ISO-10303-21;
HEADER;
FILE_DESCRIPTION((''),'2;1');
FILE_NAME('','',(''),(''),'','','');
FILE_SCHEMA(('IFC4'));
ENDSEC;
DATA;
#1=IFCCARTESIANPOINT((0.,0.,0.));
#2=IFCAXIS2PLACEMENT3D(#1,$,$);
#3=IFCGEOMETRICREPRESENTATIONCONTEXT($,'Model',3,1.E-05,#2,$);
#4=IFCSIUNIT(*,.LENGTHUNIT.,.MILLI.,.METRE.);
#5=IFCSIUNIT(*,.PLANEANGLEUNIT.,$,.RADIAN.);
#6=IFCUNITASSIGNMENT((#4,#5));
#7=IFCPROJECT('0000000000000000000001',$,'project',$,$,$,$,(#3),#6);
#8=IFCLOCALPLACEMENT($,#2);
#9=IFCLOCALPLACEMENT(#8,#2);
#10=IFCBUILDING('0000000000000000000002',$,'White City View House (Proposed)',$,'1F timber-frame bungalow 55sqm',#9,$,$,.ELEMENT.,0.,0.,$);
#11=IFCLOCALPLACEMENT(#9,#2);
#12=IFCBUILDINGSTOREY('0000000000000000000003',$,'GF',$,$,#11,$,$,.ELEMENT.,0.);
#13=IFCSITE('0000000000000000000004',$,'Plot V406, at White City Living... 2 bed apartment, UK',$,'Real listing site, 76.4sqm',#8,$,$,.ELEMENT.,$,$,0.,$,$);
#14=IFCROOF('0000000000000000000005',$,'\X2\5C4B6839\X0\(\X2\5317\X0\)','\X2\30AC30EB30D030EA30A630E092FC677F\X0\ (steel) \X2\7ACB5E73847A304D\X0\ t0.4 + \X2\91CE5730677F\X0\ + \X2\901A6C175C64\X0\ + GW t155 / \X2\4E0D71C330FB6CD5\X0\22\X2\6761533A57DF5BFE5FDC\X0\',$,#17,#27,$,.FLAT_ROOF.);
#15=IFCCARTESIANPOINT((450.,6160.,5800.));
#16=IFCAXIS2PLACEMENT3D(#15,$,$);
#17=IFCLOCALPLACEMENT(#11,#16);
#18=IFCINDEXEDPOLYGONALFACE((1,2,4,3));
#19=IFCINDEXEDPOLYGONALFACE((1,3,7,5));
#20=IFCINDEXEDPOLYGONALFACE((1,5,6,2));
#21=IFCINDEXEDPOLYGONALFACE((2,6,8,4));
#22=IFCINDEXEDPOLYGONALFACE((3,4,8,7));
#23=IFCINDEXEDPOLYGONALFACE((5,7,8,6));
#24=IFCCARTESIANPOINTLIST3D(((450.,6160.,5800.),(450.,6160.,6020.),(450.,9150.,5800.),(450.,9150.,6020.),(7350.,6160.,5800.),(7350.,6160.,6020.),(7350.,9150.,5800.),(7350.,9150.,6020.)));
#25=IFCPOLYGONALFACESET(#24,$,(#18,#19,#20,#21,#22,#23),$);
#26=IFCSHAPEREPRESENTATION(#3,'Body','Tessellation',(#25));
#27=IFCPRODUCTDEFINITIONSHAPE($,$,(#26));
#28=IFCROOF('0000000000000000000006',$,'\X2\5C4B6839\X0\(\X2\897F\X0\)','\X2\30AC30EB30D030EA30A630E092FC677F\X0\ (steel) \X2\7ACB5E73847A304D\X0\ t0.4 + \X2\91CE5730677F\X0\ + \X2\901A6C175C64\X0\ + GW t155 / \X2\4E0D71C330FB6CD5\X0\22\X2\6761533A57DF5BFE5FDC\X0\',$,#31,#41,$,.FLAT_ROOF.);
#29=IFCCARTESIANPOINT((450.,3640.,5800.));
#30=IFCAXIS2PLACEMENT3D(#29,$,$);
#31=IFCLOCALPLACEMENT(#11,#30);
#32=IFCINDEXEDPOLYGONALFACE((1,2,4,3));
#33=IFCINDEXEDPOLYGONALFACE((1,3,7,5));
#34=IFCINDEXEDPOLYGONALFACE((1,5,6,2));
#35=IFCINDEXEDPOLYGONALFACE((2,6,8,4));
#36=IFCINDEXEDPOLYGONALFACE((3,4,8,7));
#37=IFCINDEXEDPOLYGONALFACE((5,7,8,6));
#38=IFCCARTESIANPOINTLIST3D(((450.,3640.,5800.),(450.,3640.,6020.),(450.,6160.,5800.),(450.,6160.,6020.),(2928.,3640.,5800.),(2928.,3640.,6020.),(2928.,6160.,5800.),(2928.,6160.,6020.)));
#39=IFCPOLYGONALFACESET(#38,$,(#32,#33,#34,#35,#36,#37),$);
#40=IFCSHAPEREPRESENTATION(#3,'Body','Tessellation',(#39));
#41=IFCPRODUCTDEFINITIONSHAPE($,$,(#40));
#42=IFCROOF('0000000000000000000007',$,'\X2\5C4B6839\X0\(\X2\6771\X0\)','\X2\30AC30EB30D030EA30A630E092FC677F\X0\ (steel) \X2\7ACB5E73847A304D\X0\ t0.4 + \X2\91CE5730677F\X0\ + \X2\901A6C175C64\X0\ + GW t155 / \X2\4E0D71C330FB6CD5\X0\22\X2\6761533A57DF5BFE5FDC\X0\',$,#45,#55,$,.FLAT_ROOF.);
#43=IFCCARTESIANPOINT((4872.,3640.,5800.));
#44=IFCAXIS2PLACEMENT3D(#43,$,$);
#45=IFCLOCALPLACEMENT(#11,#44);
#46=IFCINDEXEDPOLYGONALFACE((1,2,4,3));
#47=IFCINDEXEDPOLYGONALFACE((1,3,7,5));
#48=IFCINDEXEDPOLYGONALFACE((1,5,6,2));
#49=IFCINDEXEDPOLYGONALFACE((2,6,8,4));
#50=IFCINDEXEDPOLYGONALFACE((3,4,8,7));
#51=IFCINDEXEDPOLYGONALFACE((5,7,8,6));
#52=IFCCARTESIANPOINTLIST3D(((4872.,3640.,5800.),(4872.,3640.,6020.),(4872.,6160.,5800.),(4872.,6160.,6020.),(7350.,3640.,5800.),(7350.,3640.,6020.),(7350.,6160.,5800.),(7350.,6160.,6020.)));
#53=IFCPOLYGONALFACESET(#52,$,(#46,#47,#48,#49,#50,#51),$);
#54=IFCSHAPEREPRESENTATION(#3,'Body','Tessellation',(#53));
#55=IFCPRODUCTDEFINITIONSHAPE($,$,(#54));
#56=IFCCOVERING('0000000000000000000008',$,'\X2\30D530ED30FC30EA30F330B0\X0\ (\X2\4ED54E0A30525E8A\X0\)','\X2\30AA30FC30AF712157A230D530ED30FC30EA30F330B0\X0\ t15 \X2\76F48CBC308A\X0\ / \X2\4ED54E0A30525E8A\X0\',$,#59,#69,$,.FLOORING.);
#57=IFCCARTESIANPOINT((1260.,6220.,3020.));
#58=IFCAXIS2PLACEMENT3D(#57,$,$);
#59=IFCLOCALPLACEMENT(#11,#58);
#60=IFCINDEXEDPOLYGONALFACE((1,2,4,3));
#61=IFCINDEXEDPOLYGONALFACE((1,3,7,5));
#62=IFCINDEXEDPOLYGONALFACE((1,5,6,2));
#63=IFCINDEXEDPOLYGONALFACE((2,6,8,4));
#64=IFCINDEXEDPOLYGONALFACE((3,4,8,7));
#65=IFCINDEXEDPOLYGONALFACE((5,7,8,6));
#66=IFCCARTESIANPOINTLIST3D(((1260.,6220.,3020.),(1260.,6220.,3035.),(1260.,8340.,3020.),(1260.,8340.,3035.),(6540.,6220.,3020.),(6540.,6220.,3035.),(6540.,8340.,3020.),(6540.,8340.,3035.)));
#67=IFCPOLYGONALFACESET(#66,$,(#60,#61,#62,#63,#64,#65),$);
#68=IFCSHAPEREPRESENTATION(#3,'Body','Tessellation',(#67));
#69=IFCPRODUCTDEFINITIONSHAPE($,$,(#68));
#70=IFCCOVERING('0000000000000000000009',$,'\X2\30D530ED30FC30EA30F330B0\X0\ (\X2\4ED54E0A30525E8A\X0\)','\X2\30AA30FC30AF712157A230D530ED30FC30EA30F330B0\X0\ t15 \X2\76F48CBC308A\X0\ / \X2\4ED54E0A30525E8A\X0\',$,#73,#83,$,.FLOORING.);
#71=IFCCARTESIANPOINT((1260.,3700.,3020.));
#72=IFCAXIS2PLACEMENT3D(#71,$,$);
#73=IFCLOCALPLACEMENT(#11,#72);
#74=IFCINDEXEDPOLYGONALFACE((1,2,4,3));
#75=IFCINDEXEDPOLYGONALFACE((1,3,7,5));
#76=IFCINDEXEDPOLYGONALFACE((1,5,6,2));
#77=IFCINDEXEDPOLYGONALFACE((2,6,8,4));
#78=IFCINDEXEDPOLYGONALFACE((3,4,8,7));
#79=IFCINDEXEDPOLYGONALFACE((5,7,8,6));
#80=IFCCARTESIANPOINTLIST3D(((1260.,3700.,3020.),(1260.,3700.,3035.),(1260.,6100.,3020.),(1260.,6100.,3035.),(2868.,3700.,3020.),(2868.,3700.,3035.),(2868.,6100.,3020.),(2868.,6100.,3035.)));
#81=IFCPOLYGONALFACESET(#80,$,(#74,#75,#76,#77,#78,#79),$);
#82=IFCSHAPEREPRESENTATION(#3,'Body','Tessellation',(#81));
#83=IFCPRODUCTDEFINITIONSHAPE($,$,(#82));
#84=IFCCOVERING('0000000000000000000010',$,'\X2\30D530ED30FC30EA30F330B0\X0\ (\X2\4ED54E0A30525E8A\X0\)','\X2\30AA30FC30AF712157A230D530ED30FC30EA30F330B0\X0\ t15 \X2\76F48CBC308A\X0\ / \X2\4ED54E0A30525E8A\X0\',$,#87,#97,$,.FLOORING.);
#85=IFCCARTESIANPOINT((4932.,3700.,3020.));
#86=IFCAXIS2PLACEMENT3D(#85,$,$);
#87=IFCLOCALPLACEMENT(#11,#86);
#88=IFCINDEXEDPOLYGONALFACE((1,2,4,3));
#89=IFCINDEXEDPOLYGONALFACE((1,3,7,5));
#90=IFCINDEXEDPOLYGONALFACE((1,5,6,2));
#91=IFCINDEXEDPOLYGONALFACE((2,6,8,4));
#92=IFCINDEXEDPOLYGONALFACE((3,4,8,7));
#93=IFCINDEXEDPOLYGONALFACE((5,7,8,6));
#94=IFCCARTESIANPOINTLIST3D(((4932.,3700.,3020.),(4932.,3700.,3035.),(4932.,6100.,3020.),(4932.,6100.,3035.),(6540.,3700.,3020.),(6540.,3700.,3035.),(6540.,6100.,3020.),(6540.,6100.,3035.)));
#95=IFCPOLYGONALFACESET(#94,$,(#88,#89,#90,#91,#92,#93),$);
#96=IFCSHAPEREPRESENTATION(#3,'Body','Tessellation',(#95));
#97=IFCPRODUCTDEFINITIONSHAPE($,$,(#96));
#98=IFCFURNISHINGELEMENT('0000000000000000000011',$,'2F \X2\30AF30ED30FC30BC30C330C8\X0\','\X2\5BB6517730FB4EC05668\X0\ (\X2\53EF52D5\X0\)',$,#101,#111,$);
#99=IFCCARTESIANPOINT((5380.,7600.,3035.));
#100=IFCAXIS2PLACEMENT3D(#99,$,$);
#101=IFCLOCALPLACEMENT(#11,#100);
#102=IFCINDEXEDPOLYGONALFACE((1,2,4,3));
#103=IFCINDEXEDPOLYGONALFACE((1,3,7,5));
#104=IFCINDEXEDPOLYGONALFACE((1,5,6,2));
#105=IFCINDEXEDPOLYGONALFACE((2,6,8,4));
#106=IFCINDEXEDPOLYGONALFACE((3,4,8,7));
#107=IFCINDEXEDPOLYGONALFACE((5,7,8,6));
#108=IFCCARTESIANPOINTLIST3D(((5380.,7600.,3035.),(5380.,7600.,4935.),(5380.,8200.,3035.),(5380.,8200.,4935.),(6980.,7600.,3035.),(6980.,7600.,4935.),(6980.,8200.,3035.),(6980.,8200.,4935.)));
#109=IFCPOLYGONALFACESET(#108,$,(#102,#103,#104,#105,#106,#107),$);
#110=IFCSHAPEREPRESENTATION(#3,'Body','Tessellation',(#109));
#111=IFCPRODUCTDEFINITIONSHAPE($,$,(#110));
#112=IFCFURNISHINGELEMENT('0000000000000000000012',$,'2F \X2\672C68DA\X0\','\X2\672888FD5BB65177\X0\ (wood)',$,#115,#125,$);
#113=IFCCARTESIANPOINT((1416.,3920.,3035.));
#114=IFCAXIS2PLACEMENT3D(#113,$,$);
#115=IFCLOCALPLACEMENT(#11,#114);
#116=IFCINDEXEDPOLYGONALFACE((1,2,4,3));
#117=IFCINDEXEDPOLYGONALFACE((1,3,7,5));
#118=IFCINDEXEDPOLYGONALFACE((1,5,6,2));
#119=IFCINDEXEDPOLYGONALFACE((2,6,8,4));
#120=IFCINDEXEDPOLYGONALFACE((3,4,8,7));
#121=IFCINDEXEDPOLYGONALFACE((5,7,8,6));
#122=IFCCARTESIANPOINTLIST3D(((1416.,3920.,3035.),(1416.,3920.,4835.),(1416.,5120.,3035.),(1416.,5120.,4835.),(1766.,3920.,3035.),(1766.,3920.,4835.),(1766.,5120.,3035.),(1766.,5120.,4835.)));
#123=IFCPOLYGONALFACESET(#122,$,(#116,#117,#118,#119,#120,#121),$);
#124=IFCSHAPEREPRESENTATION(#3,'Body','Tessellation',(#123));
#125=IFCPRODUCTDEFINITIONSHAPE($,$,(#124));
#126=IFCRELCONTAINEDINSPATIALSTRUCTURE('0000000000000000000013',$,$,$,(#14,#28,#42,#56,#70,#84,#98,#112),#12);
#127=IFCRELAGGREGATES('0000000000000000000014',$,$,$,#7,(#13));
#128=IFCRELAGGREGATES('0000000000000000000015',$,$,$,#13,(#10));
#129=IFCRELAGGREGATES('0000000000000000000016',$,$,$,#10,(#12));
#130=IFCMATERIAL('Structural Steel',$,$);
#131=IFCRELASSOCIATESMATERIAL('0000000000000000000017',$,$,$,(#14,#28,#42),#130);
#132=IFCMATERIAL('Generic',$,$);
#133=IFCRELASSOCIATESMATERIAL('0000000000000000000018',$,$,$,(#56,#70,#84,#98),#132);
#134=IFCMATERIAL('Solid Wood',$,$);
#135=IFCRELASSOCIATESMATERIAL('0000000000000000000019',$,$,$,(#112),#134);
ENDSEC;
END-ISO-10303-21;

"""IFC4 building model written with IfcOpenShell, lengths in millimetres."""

from ifc_helpers import new_model, si_unit, frame, frame_2d, origin, place, context, project, spatial, rectangle, extrude, material, element, save


model = new_model("IFC4")

# Units and contexts
model_context = context("Model", 3, precision=1e-05, world=origin())
ifc_project = project(units=[si_unit("LENGTHUNIT", "METRE", prefix="MILLI"), si_unit("PLANEANGLEUNIT", "RADIAN")], contexts=[model_context])

# Site, building, storey
site_placement = place(None, origin())
site = spatial("IfcSite", under=ifc_project, at=site_placement, Name="Plot V406, at White City Living... 2 bed apartment, UK", ObjectType="Real listing site, 76.4sqm", CompositionType="ELEMENT", RefElevation=0.0)
building_placement = place(site_placement, origin())
building = spatial("IfcBuilding", under=site, at=building_placement, Name="White City View House (Proposed)", ObjectType="1F timber-frame bungalow 55sqm", CompositionType="ELEMENT", ElevationOfRefHeight=0.0, ElevationOfTerrain=0.0)
storey_placement = place(building_placement, origin())
storey = spatial("IfcBuildingStorey", under=building, at=storey_placement, Name="GF", CompositionType="ELEMENT", Elevation=0.0)

# Shared definitions
ifc_material_1 = material(Name="Solid Wood")

# Shared definitions
ifc_material_2 = material(Name="Generic")

# Roofs
ifc_material_3 = material(Name="Structural Steel")
for number, where, name in (
    (1, (450.0, 6160.0, 5800.0), "屋根(北)"),
):
    element("IfcRoof", number, at=place(storey_placement, frame(where)), inside=storey, material=ifc_material_3, Name=name, Description="ガルバリウム鋼板 (steel) 立平葺き t0.4 + 野地板 + 通気層 + GW t155 / 不燃・法22条区域対応", PredefinedType="FLAT_ROOF", context=model_context, shape_type="SweptSolid", body=[
        extrude(rectangle(XDim=6900.0, YDim=2990.0, at=frame_2d((3450.0, 1495.0))), frame((450.0, 6160.0, 5800.0)), (0.0, 0.0, 1.0), 220.0),
    ])
roof_1_placement = place(storey_placement, frame((450.0, 3640.0, 5800.0)))
element("IfcRoof", 2, at=roof_1_placement, inside=storey, material=ifc_material_3, Name="屋根(西)", Description="ガルバリウム鋼板 (steel) 立平葺き t0.4 + 野地板 + 通気層 + GW t155 / 不燃・法22条区域対応", PredefinedType="FLAT_ROOF", context=model_context, shape_type="SweptSolid", body=[
    extrude(rectangle(XDim=2478.0, YDim=2520.0, at=frame_2d((1239.0, 1260.0))), frame((450.0, 3640.0, 5800.0)), (0.0, 0.0, 1.0), 220.0),
])
roof_2_placement = place(storey_placement, frame((4872.0, 3640.0, 5800.0)))
element("IfcRoof", 3, at=roof_2_placement, inside=storey, material=ifc_material_3, Name="屋根(東)", Description="ガルバリウム鋼板 (steel) 立平葺き t0.4 + 野地板 + 通気層 + GW t155 / 不燃・法22条区域対応", PredefinedType="FLAT_ROOF", context=model_context, shape_type="SweptSolid", body=[
    extrude(rectangle(XDim=2478.0, YDim=2520.0, at=frame_2d((1239.0, 1260.0))), frame((4872.0, 3640.0, 5800.0)), (0.0, 0.0, 1.0), 220.0),
])

# Coverings
covering_1_placement = place(storey_placement, frame((1260.0, 6220.0, 3020.0)))
element("IfcCovering", 4, at=covering_1_placement, inside=storey, material=ifc_material_2, Name="フローリング (仕上げ床)", Description="オーク無垢フローリング t15 直貼り / 仕上げ床", PredefinedType="FLOORING", context=model_context, shape_type="SweptSolid", body=[
    extrude(rectangle(XDim=5280.0, YDim=2120.0, at=frame_2d((2640.0, 1060.0))), frame((1260.0, 6220.0, 3020.0)), (0.0, 0.0, 1.0), 15.0),
])
covering_2_placement = place(storey_placement, frame((1260.0, 3700.0, 3020.0)))
element("IfcCovering", 5, at=covering_2_placement, inside=storey, material=ifc_material_2, Name="フローリング (仕上げ床)", Description="オーク無垢フローリング t15 直貼り / 仕上げ床", PredefinedType="FLOORING", context=model_context, shape_type="SweptSolid", body=[
    extrude(rectangle(XDim=1608.0, YDim=2400.0, at=frame_2d((804.0, 1200.0))), frame((1260.0, 3700.0, 3020.0)), (0.0, 0.0, 1.0), 15.0),
])
covering_3_placement = place(storey_placement, frame((4932.0, 3700.0, 3020.0)))
element("IfcCovering", 6, at=covering_3_placement, inside=storey, material=ifc_material_2, Name="フローリング (仕上げ床)", Description="オーク無垢フローリング t15 直貼り / 仕上げ床", PredefinedType="FLOORING", context=model_context, shape_type="SweptSolid", body=[
    extrude(rectangle(XDim=1608.0, YDim=2400.0, at=frame_2d((804.0, 1200.0))), frame((4932.0, 3700.0, 3020.0)), (0.0, 0.0, 1.0), 15.0),
])

# Furnishing elements
furnishing_1_placement = place(storey_placement, frame((5380.0, 7600.0, 3035.0)))
element("IfcFurnishingElement", 7, at=furnishing_1_placement, inside=storey, material=ifc_material_2, Name="2F クローゼット", Description="家具・什器 (可動)", context=model_context, shape_type="SweptSolid", body=[
    extrude(rectangle(XDim=1600.0, YDim=600.0, at=frame_2d((800.0, 300.0))), frame((5380.0, 7600.0, 3035.0)), (0.0, 0.0, 1.0), 1900.0),
])
furnishing_2_placement = place(storey_placement, frame((1416.0, 3920.0, 3035.0)))
element("IfcFurnishingElement", 8, at=furnishing_2_placement, inside=storey, material=ifc_material_1, Name="2F 本棚", Description="木製家具 (wood)", context=model_context, shape_type="SweptSolid", body=[
    extrude(rectangle(XDim=350.0, YDim=1200.0, at=frame_2d((175.0, 600.0))), frame((1416.0, 3920.0, 3035.0)), (0.0, 0.0, 1.0), 1800.0),
])

save(model, "model.ifc")
